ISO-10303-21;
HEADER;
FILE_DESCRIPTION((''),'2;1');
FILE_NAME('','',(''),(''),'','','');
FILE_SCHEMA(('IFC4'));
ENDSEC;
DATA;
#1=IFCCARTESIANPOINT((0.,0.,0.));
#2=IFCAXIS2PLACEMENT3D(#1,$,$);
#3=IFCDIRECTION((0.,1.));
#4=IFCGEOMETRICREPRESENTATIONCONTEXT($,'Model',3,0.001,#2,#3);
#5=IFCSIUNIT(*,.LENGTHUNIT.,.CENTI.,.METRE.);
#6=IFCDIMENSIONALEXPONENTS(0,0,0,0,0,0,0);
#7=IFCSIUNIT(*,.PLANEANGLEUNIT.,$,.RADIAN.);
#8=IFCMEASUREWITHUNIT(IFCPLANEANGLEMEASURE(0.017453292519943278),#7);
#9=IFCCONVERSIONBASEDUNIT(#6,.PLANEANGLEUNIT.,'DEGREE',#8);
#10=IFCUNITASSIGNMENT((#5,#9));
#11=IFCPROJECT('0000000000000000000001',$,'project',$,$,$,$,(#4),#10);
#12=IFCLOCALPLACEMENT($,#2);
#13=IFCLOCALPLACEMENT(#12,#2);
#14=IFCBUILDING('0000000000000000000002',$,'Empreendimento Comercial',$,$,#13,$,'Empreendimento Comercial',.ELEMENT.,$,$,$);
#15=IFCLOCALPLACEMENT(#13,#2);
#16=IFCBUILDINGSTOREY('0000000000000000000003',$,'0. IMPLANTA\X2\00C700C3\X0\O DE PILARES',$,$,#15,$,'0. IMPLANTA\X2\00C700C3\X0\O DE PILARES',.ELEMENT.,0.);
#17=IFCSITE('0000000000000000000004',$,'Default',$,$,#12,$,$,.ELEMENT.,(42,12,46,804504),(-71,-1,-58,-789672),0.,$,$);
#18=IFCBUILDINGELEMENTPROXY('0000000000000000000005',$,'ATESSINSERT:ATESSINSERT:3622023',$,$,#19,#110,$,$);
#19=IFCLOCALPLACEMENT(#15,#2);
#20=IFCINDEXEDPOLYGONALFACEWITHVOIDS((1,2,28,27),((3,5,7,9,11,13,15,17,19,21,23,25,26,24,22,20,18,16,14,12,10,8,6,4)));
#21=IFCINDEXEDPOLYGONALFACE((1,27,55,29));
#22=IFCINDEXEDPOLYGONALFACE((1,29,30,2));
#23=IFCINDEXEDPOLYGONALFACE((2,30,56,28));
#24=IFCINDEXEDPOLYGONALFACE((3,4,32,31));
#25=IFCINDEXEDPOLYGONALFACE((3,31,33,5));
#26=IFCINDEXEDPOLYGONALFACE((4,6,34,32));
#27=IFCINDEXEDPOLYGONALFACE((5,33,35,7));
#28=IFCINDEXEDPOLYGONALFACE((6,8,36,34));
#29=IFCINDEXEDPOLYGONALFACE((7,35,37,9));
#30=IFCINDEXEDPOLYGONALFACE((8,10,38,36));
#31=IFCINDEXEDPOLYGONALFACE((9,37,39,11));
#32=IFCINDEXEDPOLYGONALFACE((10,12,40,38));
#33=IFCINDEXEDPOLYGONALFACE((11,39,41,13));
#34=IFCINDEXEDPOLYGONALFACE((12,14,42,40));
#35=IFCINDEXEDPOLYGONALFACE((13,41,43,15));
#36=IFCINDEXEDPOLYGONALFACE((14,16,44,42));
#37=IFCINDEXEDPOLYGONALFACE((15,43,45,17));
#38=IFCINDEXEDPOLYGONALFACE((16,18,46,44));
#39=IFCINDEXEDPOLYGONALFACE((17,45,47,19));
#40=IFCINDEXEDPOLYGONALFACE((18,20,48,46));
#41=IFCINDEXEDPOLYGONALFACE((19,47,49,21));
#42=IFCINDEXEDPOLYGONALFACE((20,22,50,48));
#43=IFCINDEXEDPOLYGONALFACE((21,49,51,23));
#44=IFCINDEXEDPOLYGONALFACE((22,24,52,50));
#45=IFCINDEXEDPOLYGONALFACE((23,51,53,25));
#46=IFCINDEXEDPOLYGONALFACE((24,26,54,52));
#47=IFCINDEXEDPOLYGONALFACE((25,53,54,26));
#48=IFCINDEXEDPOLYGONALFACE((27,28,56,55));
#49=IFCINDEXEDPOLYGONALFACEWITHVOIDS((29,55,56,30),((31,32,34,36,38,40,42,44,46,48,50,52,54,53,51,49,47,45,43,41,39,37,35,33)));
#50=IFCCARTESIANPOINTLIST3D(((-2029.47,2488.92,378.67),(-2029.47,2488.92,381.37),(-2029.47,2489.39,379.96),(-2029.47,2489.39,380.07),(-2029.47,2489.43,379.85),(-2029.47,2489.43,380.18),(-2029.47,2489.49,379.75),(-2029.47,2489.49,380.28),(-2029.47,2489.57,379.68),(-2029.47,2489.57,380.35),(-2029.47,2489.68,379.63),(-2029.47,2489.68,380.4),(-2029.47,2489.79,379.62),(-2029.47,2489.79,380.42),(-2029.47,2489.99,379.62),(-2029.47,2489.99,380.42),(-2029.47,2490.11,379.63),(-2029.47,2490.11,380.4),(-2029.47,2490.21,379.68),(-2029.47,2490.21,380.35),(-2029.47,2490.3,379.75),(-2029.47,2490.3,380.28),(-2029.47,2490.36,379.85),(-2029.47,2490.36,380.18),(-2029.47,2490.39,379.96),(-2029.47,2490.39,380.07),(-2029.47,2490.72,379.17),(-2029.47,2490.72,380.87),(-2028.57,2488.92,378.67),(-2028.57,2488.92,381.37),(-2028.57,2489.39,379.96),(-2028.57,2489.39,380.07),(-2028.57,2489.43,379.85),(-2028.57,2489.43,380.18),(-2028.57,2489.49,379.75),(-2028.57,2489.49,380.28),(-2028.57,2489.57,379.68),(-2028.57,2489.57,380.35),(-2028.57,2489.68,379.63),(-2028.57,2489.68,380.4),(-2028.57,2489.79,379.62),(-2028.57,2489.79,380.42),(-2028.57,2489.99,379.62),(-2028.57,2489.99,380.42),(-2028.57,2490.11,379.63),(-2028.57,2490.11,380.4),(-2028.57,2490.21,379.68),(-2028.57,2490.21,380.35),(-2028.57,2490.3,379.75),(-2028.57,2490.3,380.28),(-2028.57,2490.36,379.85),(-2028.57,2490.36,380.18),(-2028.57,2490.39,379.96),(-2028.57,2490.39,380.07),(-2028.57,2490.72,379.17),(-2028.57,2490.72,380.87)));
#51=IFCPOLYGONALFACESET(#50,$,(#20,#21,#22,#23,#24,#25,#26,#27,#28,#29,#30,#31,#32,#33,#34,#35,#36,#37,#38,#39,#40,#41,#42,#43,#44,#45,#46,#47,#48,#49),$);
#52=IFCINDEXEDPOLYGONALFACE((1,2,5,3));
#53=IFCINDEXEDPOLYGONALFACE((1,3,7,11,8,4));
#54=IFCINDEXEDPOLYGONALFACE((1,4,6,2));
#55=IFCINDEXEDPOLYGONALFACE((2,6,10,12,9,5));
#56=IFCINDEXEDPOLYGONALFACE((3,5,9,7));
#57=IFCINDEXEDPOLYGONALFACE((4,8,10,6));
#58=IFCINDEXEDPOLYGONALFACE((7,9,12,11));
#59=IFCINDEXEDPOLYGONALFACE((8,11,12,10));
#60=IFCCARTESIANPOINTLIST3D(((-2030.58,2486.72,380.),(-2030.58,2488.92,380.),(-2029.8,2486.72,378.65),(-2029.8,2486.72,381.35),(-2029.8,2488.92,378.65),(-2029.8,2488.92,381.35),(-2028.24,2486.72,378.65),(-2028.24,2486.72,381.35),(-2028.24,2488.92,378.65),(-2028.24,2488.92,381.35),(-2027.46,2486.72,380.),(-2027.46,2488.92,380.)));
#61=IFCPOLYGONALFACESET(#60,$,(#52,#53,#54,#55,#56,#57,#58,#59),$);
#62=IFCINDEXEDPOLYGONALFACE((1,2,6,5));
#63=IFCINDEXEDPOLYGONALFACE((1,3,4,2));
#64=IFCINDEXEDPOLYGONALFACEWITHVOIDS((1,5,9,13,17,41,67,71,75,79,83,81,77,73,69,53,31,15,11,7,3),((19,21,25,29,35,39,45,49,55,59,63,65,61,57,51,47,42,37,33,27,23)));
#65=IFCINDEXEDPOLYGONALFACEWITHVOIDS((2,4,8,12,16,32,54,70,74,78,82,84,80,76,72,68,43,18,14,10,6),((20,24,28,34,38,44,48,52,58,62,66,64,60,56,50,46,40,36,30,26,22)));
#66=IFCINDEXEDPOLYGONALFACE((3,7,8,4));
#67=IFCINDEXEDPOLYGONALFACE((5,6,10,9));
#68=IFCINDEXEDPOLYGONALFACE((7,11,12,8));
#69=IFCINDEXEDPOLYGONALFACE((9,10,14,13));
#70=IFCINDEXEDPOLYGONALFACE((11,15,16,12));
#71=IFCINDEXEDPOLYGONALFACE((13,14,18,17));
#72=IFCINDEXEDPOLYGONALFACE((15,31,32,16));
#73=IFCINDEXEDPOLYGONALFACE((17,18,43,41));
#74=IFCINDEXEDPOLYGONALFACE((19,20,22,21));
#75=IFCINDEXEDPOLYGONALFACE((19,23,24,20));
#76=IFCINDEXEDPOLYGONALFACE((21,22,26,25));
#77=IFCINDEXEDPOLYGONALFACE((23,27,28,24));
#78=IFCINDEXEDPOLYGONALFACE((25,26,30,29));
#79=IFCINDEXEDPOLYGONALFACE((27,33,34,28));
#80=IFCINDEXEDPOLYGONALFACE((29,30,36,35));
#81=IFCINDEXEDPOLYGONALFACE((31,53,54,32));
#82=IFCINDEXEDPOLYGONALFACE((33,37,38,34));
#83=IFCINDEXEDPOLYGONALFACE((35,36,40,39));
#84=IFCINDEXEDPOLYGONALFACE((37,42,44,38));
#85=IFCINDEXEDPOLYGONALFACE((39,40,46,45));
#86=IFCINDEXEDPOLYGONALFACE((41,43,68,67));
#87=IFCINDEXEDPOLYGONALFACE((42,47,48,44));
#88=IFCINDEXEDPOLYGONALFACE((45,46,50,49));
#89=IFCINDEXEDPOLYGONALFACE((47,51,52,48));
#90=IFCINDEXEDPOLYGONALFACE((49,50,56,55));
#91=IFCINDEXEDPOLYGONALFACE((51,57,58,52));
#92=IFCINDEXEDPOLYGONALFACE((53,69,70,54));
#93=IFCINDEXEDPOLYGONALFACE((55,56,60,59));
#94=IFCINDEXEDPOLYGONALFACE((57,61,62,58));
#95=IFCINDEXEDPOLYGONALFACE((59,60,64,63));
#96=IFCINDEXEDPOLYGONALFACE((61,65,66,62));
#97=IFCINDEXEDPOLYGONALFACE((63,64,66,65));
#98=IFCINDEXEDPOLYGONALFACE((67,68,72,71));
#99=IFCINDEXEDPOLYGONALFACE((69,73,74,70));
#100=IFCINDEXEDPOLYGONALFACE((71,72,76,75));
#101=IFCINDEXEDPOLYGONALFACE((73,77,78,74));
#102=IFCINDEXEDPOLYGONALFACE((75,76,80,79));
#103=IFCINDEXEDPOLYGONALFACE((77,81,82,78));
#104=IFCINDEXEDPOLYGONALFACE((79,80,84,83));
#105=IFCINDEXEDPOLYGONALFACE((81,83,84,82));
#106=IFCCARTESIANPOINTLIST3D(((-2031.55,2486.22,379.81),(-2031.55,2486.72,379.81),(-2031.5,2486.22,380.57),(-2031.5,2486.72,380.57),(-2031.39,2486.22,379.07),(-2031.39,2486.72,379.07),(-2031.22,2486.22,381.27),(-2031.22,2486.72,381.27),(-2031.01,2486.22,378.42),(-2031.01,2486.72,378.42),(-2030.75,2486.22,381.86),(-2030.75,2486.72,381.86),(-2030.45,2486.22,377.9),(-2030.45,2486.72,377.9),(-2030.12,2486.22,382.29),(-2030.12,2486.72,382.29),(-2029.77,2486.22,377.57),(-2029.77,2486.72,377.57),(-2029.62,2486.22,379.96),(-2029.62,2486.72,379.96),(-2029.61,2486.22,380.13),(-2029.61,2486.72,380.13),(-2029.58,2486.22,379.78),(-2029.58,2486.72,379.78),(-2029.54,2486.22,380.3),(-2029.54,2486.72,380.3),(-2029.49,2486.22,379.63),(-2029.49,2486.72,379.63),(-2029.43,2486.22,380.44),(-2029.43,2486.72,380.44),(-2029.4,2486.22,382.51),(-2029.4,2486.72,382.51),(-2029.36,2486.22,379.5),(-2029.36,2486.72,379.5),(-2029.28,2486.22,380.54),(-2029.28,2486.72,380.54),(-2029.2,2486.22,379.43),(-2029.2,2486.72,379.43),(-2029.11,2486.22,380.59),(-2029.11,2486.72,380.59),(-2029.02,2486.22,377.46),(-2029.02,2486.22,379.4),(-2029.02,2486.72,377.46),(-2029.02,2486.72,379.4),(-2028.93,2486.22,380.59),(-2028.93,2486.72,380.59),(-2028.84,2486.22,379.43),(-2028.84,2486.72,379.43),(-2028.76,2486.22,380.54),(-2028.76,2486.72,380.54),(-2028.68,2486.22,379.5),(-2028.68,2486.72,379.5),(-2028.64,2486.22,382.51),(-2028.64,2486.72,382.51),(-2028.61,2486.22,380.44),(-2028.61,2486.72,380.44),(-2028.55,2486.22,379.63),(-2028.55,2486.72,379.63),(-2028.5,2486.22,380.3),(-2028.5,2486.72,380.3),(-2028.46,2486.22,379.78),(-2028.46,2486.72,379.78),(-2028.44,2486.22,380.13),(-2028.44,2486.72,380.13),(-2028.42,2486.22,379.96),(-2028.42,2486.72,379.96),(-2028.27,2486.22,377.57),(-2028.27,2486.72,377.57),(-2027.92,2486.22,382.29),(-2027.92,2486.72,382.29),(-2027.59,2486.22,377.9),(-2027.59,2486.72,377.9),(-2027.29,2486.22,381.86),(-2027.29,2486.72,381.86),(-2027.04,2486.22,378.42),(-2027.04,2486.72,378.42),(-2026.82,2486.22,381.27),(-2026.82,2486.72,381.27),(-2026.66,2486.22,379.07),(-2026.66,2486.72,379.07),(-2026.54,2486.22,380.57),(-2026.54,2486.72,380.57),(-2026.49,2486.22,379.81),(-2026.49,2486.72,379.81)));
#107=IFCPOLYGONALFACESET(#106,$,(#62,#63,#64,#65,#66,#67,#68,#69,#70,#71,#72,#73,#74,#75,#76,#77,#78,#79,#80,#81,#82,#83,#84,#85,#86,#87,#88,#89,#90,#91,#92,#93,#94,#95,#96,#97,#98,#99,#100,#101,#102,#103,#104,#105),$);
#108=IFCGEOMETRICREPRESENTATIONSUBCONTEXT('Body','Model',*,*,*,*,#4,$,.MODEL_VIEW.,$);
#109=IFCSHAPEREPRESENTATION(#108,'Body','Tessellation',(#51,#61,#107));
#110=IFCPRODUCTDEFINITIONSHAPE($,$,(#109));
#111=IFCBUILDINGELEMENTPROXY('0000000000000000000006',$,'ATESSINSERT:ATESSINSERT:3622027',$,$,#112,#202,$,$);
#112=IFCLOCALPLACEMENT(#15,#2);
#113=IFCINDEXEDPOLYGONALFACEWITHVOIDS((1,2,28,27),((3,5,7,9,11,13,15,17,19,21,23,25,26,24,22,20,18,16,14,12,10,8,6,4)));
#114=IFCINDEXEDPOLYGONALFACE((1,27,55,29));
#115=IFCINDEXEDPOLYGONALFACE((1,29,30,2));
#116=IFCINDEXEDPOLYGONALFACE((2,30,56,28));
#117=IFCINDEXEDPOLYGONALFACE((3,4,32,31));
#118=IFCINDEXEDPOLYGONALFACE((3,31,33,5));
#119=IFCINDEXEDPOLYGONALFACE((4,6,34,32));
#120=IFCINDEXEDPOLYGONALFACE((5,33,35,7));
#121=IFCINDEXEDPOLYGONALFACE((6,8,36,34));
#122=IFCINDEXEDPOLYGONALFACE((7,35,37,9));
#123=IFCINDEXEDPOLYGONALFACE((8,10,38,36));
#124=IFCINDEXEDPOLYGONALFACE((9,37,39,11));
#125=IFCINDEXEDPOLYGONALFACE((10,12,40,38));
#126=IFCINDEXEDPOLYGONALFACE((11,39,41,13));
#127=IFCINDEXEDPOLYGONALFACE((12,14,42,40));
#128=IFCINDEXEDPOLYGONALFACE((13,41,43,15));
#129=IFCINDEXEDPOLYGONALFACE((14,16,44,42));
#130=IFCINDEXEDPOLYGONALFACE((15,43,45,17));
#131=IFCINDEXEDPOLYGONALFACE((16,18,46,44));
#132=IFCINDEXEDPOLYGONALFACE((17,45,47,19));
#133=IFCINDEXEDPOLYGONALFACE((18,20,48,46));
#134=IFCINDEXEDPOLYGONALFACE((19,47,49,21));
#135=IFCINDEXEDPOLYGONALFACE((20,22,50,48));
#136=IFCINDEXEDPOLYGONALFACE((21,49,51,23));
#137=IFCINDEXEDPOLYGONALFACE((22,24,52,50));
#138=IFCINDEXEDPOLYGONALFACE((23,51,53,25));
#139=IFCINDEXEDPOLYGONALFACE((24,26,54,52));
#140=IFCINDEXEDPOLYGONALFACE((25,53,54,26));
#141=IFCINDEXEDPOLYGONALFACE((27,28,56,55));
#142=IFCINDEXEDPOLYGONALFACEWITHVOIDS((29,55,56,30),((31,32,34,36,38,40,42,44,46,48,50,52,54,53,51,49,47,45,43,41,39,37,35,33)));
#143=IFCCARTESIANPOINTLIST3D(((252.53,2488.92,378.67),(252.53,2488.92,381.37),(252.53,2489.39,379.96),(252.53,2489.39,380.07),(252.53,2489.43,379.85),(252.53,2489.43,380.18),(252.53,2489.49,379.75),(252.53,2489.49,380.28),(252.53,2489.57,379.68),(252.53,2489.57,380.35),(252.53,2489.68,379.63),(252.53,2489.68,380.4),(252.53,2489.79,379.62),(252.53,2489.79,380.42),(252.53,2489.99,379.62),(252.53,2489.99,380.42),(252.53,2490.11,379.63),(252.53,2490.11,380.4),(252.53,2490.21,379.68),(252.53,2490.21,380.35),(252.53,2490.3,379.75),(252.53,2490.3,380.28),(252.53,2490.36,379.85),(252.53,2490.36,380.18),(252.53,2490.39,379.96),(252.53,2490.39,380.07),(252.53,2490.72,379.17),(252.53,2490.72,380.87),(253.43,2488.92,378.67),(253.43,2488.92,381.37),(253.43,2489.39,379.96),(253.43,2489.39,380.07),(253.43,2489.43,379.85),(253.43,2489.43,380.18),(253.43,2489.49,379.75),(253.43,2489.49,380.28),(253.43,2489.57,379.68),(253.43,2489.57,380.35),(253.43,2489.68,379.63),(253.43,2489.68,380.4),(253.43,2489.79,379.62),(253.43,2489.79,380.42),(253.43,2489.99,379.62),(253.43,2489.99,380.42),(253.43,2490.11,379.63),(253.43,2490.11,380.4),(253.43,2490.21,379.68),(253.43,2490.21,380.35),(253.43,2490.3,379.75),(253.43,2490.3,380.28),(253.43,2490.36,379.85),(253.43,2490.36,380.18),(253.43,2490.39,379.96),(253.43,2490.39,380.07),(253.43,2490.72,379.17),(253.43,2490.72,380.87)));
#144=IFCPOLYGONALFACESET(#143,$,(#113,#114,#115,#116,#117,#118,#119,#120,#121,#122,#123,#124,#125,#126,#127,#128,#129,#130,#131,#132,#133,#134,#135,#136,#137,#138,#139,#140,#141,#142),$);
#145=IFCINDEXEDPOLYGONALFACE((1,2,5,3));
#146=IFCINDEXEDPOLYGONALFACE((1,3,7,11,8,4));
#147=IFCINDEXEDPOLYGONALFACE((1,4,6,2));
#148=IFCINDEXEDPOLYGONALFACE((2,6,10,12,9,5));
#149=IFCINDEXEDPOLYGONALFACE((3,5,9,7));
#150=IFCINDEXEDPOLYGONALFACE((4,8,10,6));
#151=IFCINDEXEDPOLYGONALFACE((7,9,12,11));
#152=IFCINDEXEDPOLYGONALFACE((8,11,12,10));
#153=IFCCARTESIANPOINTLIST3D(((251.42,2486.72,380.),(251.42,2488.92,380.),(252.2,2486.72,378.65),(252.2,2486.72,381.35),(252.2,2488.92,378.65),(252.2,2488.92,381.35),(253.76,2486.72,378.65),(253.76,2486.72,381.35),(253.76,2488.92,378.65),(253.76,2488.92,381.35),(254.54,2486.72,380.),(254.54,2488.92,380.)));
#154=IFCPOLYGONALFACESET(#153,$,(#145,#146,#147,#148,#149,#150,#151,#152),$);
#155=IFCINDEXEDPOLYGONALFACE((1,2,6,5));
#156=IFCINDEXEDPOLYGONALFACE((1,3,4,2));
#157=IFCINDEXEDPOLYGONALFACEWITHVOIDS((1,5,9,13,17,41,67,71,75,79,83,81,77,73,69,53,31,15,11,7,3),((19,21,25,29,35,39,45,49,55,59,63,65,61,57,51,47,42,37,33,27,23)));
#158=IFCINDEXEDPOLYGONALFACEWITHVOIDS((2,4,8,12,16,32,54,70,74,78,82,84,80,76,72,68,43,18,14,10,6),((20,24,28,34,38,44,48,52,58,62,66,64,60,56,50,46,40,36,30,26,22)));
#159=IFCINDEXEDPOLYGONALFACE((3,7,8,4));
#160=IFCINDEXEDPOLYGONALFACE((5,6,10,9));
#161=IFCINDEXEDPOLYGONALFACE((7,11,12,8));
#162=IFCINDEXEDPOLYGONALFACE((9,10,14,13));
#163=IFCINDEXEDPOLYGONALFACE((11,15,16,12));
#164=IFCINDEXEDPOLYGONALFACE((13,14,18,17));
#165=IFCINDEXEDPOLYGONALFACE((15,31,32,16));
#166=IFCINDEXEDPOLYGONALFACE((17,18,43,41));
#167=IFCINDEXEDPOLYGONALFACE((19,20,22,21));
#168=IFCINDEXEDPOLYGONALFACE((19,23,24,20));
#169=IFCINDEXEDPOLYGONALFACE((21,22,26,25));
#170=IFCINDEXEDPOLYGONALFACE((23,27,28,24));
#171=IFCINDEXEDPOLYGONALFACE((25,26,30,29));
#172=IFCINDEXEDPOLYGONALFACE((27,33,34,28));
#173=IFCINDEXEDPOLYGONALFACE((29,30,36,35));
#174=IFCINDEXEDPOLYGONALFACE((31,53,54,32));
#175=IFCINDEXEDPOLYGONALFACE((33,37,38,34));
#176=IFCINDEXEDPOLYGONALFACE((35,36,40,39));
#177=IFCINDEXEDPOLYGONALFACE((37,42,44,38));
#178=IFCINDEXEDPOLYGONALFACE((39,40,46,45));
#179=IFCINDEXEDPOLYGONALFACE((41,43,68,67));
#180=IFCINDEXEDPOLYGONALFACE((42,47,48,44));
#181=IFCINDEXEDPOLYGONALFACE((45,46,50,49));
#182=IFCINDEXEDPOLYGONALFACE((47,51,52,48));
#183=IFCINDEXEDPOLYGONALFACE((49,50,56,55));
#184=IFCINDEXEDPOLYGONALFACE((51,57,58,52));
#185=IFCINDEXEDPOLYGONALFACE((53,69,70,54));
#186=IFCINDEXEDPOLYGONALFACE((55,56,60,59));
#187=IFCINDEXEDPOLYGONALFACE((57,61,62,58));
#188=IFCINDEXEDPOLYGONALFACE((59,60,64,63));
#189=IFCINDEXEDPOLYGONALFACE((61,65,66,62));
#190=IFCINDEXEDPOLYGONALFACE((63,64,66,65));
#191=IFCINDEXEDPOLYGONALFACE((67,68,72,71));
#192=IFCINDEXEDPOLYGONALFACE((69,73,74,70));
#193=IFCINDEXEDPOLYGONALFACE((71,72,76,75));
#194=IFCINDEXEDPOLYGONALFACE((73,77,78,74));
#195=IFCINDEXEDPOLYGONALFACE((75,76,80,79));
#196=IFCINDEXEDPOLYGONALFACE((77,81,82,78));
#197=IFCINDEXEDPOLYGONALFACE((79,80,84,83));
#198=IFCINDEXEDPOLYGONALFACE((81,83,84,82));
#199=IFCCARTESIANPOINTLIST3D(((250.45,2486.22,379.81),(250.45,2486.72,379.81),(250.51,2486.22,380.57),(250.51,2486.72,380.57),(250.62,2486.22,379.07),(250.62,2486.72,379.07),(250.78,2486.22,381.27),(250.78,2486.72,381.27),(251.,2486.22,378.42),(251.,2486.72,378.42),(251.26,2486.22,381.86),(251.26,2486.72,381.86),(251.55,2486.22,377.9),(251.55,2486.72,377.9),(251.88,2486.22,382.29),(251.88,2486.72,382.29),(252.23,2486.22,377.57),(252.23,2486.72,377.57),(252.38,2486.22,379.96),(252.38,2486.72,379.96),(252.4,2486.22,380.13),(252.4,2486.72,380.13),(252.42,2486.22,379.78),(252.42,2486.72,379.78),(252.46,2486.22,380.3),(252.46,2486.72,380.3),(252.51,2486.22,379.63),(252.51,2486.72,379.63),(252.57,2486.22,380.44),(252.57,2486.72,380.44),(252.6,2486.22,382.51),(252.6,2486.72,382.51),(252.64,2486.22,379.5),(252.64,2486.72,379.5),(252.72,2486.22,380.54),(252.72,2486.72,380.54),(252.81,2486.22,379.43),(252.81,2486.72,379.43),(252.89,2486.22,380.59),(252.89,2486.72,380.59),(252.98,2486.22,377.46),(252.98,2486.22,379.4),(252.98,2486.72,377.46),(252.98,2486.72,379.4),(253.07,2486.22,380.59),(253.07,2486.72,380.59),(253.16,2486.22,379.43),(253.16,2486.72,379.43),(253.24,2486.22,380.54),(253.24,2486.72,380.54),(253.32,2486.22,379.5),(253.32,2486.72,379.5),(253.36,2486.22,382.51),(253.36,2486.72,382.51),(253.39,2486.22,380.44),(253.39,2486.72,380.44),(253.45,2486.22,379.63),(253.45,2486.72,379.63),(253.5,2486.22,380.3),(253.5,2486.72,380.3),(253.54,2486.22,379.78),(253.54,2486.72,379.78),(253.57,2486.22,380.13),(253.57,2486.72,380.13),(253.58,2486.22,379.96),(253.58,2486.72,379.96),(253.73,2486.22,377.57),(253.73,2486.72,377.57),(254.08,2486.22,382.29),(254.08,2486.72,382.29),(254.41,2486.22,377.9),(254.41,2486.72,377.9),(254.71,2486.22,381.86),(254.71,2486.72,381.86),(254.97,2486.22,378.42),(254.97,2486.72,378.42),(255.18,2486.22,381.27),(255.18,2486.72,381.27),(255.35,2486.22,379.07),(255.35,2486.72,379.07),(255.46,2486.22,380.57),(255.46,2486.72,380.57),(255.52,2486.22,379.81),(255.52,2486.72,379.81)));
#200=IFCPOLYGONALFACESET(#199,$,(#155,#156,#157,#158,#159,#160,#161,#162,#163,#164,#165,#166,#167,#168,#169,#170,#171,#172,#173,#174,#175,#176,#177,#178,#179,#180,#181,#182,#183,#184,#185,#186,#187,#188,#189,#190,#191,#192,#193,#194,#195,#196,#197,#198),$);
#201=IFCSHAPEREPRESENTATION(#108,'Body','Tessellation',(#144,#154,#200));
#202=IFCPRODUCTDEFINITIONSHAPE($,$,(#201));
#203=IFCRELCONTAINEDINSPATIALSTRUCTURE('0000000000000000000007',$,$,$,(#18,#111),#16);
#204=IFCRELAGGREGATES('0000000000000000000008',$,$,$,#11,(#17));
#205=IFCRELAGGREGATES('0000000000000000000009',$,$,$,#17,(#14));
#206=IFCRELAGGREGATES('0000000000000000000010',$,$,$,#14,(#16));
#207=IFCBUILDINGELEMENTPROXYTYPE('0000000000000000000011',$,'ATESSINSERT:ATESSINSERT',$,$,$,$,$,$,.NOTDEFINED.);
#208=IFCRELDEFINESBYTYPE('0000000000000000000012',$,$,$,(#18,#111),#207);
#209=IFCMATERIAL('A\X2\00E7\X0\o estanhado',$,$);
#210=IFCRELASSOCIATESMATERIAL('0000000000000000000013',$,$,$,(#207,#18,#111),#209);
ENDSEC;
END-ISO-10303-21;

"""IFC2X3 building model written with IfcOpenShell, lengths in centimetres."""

from ifc_helpers import new_model, entity, si_unit, converted_unit, direction, frame, frame_2d, origin, place, context, subcontext, project, spatial, polyline, circle_curve, parameter, trimmed, segment, composite_curve, hollow_circle, outline, extrude, source, transform, mapped, material, type_object, type_shapes, element, save


model = new_model("IFC2X3")

# Units and contexts
model_context = context("Model", 3, precision=0.001, world=origin(), true_north=direction((0.0, 1.0)))
body_context = subcontext(model_context, "Body", "Model", "MODEL_VIEW")
ifc_project = project(units=[si_unit("LENGTHUNIT", "METRE", prefix="CENTI"), converted_unit("PLANEANGLEUNIT", "DEGREE", entity("IfcPlaneAngleMeasure", 0.017453292519943278), si_unit("PLANEANGLEUNIT", "RADIAN"), dimensions=[0, 0, 0, 0, 0, 0, 0])], contexts=[model_context])

# Site, building, storey
site_placement = place(None, origin())
site = spatial("IfcSite", under=ifc_project, at=site_placement, Name="Default", CompositionType="ELEMENT", RefLatitude=(42, 12, 46, 804504), RefLongitude=(-71, -1, -58, -789672), RefElevation=0.0)
building_placement = place(site_placement, origin())
building = spatial("IfcBuilding", under=site, at=building_placement, Name="Empreendimento Comercial", LongName="Empreendimento Comercial", CompositionType="ELEMENT")
storey_placement = place(building_placement, origin())
storey = spatial("IfcBuildingStorey", under=building, at=storey_placement, Name="0. IMPLANTAÇÃO DE PILARES", LongName="0. IMPLANTAÇÃO DE PILARES", CompositionType="ELEMENT", Elevation=0.0)

# Building element proxies
ifc_material_1 = material(Name="Aço estanhado")
building_element_proxy_type_1 = type_object("IfcBuildingElementProxyType", Name="ATESSINSERT:ATESSINSERT", PredefinedType="NOTDEFINED", material=ifc_material_1)
shared_shape_1 = source(origin(), body_context, "Body", "SweptSolid", [
    extrude(outline(polyline([(-1.35, -0.9), (1.35, -0.9), (0.85, 0.9), (-0.85, 0.9), (-1.35, -0.9)]), holes=[composite_curve([segment(trimmed(circle_curve(frame_2d((0.0, 0.17), x_axis=(1.0, 0.0)), 0.4), [parameter(0.0)], [parameter(180.0)], True, "PARAMETER"), False, "CONTINUOUS"), segment(polyline([(0.4, 0.17), (0.4, -0.03)]), True, "CONTINUOUS"), segment(trimmed(circle_curve(frame_2d((0.0, -0.03), x_axis=(1.0, 0.0)), 0.4), [parameter(180.0)], [parameter(0.0)], True, "PARAMETER"), False, "CONTINUOUS"), segment(polyline([(-0.4, -0.03), (-0.4, 0.17)]), True, "CONTINUOUS")], self_intersect=False)]), frame((-1.4, -0.45, 30.02), z_axis=(0.0, 1.0, 0.0), x_axis=(0.0, 0.0, 1.0)), (0.0, 0.0, 1.0), 0.9),
    extrude(outline(polyline([(-0.78, -1.35), (0.78, -1.35), (1.56, 0.0), (0.78, 1.35), (-0.78, 1.35), (-1.56, 0.0), (-0.78, -1.35)])), frame((-4.5, 0.0, 30.0), z_axis=(1.0, 0.0, 0.0), x_axis=(0.0, 1.0, 0.0)), (0.0, 0.0, 1.0), 2.2),
    extrude(hollow_circle(Radius=2.54, WallThickness=1.94, at=frame_2d((0.0, 0.0), x_axis=(1.0, 0.0))), frame((-5.0, 0.0, 30.0), z_axis=(1.0, 0.0, 0.0), x_axis=(0.0, 0.0, -1.0)), (0.0, 0.0, 1.0), 0.5),
])
type_shapes(building_element_proxy_type_1, [shared_shape_1])
for number, where, z_axis, x_axis, name in (
    (1, (-2029.02, 2491.22, 350.0), (0.0, 0.0, 1.0), (0.0, 1.0, 0.0), "ATESSINSERT:ATESSINSERT:3622023"),
    (2, (252.98, 2491.22, 350.0), (0.0, 0.0, 1.0), (0.0, 1.0, 0.0), "ATESSINSERT:ATESSINSERT:3622027"),
):
    element("IfcBuildingElementProxy", number, at=place(storey_placement, frame(where, z_axis=z_axis, x_axis=x_axis)), inside=storey, type_object=building_element_proxy_type_1, material=ifc_material_1, Name=name, context=body_context, shape_type="MappedRepresentation", body=[
        mapped(shared_shape_1, transform((0.0, 0.0, 0.0), scale=1.0)),
    ])

save(model, "model.ifc")
